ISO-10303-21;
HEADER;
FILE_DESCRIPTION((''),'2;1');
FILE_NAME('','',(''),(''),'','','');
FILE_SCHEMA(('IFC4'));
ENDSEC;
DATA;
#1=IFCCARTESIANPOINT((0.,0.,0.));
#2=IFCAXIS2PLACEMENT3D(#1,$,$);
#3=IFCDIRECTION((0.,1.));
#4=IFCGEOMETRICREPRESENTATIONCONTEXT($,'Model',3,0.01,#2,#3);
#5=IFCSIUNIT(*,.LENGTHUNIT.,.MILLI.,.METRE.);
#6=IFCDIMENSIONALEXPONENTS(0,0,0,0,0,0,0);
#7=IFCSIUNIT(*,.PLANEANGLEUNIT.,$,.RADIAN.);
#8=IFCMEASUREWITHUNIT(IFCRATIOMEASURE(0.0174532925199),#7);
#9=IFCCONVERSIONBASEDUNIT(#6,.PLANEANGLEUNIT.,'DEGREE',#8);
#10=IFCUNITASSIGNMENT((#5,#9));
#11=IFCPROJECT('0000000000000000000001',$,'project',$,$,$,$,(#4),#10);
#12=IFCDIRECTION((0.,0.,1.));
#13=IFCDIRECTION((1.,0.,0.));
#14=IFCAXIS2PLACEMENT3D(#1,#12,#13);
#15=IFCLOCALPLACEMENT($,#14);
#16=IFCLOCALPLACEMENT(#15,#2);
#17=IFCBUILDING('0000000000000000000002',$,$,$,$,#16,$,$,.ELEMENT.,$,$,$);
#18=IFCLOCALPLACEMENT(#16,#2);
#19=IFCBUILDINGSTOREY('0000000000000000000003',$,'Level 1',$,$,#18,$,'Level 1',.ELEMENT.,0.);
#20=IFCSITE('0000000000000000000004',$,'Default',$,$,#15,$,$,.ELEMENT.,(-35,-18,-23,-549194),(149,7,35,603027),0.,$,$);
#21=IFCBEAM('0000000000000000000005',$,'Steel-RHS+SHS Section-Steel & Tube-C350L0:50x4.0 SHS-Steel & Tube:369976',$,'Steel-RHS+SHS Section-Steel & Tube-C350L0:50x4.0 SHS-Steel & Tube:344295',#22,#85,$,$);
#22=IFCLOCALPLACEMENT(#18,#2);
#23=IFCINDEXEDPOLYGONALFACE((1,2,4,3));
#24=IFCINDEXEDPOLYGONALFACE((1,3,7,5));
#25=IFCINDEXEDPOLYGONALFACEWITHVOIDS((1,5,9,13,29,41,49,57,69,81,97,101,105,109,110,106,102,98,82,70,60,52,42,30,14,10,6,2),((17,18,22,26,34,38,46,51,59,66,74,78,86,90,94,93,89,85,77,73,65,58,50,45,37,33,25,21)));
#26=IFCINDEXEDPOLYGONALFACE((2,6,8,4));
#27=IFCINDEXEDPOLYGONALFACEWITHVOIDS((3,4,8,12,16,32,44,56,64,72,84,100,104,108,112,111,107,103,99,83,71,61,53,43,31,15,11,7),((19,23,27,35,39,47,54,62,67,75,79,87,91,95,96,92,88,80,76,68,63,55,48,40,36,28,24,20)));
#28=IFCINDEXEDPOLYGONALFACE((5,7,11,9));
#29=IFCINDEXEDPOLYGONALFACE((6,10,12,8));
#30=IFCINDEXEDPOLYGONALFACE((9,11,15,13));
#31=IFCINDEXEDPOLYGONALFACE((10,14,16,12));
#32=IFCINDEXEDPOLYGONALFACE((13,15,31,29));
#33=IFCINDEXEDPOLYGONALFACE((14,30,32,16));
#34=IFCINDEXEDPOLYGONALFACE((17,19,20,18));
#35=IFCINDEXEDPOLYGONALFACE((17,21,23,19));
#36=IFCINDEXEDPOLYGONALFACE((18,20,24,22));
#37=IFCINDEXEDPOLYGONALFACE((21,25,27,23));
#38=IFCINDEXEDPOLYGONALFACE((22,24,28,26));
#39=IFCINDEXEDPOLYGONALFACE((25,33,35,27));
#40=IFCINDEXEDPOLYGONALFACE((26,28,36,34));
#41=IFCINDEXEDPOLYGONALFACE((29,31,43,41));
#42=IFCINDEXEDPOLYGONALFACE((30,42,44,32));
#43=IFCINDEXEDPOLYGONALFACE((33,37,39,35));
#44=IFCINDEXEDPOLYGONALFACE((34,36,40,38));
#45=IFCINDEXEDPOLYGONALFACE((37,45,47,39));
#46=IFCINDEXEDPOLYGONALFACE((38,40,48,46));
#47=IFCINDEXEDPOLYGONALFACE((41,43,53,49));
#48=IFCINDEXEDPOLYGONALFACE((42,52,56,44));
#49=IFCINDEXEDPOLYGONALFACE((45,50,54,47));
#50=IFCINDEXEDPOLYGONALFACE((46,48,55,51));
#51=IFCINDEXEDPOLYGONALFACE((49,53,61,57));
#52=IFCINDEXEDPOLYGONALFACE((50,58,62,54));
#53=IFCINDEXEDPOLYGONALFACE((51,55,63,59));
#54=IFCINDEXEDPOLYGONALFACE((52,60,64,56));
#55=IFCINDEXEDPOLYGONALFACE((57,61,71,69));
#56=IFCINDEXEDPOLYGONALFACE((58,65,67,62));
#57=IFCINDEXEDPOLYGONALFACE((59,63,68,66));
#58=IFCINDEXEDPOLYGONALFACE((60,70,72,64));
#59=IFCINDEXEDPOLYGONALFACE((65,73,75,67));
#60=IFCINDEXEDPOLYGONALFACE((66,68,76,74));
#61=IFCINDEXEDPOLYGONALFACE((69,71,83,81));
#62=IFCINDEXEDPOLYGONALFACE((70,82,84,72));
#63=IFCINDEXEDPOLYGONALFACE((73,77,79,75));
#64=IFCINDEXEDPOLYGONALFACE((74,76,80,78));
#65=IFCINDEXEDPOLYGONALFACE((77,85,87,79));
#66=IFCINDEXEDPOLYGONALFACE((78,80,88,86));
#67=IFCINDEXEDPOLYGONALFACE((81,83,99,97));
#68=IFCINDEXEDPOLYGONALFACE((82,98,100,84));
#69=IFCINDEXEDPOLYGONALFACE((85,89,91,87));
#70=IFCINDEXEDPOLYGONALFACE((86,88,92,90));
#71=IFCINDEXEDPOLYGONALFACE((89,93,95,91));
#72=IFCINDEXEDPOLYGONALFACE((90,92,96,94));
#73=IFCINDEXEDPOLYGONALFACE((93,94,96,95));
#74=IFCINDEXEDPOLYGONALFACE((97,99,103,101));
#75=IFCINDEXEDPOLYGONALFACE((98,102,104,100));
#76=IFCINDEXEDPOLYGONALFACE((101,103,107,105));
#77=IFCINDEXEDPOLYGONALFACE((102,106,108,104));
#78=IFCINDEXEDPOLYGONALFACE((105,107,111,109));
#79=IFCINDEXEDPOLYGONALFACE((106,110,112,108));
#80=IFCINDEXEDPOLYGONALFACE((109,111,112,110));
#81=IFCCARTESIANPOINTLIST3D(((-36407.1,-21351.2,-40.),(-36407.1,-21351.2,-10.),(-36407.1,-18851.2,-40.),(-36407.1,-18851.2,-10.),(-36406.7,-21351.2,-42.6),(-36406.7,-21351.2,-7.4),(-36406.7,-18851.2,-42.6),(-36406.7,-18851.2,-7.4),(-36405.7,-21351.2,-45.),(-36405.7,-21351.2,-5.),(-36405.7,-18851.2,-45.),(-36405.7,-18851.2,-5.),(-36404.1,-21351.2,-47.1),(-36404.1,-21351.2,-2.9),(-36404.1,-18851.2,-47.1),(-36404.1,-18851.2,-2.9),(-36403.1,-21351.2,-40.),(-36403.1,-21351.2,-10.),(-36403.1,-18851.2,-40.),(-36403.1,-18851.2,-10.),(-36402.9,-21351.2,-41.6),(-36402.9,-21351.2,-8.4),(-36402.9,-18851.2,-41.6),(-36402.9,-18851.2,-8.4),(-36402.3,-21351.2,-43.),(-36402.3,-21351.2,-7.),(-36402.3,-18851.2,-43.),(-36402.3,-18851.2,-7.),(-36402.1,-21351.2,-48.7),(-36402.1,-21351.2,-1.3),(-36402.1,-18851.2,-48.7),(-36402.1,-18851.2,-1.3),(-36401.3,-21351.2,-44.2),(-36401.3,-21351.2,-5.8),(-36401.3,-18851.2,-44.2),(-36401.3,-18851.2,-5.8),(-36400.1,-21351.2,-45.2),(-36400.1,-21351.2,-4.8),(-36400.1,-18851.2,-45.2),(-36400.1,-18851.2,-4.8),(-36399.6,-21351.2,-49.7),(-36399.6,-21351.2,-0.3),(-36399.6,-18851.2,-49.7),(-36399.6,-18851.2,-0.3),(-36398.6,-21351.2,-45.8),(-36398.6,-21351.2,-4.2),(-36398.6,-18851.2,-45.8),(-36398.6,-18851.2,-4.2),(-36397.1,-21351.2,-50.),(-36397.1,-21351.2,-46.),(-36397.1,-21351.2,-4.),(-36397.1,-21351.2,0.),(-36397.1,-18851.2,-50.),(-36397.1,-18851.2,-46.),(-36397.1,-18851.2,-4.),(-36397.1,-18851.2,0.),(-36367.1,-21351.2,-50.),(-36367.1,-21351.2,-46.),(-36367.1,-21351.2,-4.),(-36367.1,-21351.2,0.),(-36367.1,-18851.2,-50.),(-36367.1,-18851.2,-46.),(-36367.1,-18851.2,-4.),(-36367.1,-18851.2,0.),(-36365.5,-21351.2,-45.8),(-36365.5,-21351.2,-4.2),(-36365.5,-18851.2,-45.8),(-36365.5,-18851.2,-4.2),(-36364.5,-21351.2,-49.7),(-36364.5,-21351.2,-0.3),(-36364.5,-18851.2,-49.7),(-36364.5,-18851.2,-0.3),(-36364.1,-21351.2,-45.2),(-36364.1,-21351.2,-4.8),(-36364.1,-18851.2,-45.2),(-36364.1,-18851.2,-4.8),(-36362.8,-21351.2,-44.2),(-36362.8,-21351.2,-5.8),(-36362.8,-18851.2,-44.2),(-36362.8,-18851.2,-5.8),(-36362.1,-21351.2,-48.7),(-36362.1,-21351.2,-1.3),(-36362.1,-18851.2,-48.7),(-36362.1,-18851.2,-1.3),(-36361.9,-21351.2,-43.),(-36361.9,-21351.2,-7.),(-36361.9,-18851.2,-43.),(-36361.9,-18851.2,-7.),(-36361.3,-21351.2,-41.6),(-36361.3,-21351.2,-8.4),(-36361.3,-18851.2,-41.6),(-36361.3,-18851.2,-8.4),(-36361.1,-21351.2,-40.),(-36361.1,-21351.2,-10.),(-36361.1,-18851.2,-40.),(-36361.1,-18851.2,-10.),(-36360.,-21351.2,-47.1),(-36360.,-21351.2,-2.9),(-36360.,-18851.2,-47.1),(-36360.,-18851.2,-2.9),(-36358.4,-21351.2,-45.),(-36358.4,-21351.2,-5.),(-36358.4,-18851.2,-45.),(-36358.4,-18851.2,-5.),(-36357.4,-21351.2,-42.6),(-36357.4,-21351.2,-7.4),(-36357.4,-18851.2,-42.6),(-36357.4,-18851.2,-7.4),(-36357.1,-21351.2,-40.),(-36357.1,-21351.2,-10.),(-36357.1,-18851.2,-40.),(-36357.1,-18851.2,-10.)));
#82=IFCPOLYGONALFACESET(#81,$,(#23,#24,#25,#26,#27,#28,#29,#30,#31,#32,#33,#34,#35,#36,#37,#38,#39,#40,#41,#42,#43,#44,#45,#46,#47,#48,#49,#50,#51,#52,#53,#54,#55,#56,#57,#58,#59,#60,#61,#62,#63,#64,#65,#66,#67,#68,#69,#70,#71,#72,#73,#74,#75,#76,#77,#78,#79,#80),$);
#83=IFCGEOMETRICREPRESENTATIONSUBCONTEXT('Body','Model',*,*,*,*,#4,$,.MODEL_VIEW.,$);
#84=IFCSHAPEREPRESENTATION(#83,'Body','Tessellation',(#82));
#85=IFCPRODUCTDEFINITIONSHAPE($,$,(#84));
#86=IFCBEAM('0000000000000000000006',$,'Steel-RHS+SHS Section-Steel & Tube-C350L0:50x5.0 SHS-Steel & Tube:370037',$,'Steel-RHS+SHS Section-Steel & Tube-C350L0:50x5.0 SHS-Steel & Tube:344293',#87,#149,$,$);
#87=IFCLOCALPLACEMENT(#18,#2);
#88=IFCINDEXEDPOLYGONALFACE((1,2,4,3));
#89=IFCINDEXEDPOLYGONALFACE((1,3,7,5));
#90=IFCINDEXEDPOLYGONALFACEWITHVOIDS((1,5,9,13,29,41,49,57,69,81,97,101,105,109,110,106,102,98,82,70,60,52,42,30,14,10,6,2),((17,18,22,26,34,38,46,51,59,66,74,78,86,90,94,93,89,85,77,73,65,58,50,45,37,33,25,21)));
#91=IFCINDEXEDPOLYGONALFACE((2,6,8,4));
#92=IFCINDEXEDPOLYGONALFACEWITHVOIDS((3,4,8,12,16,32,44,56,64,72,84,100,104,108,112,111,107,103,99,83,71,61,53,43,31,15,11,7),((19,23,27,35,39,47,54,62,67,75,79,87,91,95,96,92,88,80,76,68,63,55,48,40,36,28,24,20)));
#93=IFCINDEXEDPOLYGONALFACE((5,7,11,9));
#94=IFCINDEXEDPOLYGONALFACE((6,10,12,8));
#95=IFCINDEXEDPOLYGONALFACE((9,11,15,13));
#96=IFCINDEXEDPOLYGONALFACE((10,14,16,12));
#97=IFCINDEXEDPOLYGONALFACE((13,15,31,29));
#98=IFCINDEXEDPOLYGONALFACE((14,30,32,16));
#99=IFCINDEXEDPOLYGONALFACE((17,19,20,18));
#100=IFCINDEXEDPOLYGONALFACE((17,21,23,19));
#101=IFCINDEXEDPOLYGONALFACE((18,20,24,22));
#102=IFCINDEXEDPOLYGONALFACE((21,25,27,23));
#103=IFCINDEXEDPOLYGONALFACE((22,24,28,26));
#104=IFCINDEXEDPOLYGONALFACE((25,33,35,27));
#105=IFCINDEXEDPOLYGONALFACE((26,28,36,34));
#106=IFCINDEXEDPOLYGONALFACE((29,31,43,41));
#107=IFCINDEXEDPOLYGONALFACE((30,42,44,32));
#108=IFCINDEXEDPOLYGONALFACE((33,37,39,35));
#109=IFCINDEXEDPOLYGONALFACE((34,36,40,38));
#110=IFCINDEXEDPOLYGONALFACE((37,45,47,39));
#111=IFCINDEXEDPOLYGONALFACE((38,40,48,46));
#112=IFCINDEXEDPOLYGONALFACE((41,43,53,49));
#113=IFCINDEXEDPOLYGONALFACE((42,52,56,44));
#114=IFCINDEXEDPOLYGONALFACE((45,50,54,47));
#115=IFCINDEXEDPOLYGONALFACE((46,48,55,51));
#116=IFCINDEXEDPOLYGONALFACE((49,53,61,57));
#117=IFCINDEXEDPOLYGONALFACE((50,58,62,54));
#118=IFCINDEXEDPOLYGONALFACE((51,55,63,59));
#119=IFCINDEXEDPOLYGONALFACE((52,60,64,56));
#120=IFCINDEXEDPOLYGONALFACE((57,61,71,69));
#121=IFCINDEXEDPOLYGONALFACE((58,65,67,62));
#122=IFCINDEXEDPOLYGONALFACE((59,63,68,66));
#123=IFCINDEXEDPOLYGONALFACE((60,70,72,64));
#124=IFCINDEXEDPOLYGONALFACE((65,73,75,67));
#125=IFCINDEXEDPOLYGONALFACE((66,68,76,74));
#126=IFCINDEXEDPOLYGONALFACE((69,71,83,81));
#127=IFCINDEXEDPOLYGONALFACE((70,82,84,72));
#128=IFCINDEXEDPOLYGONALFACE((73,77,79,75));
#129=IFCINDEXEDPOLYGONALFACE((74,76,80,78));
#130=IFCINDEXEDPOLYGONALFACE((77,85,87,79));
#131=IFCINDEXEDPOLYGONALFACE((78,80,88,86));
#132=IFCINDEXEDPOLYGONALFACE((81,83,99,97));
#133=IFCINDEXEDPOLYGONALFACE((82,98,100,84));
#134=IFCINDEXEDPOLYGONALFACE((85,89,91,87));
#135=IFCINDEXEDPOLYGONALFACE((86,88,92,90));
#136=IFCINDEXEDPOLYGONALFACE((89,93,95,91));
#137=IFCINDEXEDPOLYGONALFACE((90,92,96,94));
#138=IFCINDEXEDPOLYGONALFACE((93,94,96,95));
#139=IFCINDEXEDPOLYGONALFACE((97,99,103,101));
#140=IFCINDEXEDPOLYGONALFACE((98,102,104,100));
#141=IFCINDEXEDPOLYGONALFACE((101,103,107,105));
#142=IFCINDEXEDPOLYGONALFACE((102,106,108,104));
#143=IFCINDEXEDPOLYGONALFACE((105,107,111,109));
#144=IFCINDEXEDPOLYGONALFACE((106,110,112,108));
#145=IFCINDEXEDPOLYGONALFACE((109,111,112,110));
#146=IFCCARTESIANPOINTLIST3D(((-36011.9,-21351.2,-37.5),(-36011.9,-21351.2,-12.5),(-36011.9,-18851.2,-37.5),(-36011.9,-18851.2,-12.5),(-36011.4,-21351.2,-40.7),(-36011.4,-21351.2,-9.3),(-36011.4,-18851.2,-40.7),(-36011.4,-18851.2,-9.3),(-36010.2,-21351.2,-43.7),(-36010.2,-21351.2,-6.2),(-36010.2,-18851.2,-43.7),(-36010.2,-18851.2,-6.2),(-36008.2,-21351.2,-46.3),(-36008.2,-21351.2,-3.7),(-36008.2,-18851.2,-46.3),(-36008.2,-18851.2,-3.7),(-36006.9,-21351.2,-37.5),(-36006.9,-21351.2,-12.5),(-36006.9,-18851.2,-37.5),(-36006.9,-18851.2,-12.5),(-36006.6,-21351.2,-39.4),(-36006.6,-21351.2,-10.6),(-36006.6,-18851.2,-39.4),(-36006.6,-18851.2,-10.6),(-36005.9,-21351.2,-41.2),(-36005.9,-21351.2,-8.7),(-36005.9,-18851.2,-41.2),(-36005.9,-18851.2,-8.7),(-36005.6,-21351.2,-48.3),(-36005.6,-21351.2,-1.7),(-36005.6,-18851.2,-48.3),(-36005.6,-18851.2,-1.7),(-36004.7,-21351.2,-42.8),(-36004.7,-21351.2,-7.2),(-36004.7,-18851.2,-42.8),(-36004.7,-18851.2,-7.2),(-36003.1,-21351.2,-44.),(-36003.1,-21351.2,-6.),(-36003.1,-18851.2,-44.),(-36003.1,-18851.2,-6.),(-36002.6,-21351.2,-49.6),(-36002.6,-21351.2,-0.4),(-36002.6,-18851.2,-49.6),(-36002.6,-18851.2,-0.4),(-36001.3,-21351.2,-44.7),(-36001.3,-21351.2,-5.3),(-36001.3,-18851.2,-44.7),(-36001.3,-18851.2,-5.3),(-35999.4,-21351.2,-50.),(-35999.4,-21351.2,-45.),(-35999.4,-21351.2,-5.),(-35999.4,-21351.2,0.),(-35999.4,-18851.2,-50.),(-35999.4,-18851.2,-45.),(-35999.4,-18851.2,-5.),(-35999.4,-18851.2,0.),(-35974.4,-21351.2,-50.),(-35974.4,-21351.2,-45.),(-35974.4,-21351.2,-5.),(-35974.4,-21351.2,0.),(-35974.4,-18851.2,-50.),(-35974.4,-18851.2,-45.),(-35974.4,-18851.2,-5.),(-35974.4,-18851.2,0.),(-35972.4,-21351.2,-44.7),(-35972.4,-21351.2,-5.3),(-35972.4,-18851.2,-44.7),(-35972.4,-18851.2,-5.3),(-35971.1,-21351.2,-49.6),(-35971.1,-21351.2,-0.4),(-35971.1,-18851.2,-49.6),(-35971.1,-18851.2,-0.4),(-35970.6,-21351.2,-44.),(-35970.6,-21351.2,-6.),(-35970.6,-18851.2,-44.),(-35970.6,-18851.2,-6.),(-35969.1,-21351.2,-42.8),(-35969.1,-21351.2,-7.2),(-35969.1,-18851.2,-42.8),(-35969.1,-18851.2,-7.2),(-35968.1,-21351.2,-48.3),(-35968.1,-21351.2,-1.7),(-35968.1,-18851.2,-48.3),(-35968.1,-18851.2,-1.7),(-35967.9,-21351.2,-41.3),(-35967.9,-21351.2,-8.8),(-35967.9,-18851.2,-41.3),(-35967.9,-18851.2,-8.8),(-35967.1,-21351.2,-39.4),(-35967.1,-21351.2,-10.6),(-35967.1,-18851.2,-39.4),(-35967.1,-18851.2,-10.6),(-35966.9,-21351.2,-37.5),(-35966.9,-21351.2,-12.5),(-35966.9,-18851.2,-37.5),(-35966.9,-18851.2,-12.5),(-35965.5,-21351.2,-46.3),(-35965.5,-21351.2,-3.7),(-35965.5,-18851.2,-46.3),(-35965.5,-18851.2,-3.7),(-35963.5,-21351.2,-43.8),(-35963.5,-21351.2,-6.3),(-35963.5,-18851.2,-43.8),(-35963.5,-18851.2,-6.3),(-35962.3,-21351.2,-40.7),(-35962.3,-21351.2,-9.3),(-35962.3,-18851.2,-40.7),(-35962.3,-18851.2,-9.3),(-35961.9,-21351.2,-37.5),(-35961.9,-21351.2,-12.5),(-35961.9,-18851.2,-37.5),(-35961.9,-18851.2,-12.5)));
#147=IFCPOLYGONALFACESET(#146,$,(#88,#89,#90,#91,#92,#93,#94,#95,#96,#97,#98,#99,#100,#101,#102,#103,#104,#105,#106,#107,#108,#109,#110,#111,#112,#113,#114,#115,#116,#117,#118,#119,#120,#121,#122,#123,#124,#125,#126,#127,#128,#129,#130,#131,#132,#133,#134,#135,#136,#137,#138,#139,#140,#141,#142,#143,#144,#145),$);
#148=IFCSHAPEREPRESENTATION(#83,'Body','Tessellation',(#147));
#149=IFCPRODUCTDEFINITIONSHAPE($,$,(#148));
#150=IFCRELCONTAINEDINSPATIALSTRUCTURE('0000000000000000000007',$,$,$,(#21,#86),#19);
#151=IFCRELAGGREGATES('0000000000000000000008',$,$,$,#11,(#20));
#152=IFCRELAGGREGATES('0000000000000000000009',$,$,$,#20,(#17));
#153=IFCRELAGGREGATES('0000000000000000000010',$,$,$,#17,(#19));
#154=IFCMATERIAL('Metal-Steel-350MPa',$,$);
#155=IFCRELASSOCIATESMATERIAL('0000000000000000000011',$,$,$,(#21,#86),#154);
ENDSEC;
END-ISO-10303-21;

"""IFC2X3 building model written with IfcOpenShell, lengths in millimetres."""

from ifc_helpers import new_model, entity, si_unit, converted_unit, direction, frame, frame_2d, origin, origin_with_axes, place, context, subcontext, project, spatial, polyline, circle_curve, parameter, trimmed, segment, composite_curve, outline, extrude, material, element, save


model = new_model("IFC2X3")

# Units and contexts
model_context = context("Model", 3, precision=0.01, world=origin(), true_north=direction((0.0, 1.0)))
body_context = subcontext(model_context, "Body", "Model", "MODEL_VIEW")
ifc_project = project(units=[si_unit("LENGTHUNIT", "METRE", prefix="MILLI"), converted_unit("PLANEANGLEUNIT", "DEGREE", entity("IfcRatioMeasure", 0.0174532925199), si_unit("PLANEANGLEUNIT", "RADIAN"), dimensions=[0, 0, 0, 0, 0, 0, 0])], contexts=[model_context])

# Site, building, storey
site_placement = place(None, origin_with_axes())
site = spatial("IfcSite", under=ifc_project, at=site_placement, Name="Default", CompositionType="ELEMENT", RefLatitude=(-35, -18, -23, -549194), RefLongitude=(149, 7, 35, 603027), RefElevation=0.0)
building_placement = place(site_placement, origin())
building = spatial("IfcBuilding", under=site, at=building_placement, CompositionType="ELEMENT")
storey_placement = place(building_placement, origin())
storey = spatial("IfcBuildingStorey", under=building, at=storey_placement, Name="Level 1", LongName="Level 1", CompositionType="ELEMENT", Elevation=0.0)

# Beams
ifc_material = material(Name="Metal-Steel-350MPa")
beam_1_placement = place(storey_placement, frame((-36382.1, -18851.2, 0.0), z_axis=(0.0, 0.0, 1.0), x_axis=(0.0, -1.0, 0.0)))
element("IfcBeam", 1, at=beam_1_placement, inside=storey, material=ifc_material, Name="Steel-RHS+SHS Section-Steel & Tube-C350L0:50x4.0 SHS-Steel & Tube:369976", ObjectType="Steel-RHS+SHS Section-Steel & Tube-C350L0:50x4.0 SHS-Steel & Tube:344295", context=body_context, shape_type="SweptSolid", body=[
    extrude(outline(composite_curve([segment(trimmed(circle_curve(frame_2d((-15.0, -15.0), x_axis=(1.0, 0.0)), 10.0), [parameter(180.0)], [parameter(270.0)], True, "PARAMETER"), True, "CONTINUOUS"), segment(polyline([(-15.0, -25.0), (15.0, -25.0)]), True, "CONTINUOUS"), segment(trimmed(circle_curve(frame_2d((15.0, -15.0), x_axis=(1.0, 0.0)), 10.0), [parameter(270.0)], [parameter(0.0)], True, "PARAMETER"), True, "CONTINUOUS"), segment(polyline([(25.0, -15.0), (25.0, 15.0)]), True, "CONTINUOUS"), segment(trimmed(circle_curve(frame_2d((15.0, 15.0), x_axis=(1.0, 0.0)), 10.0), [parameter(0.0)], [parameter(90.0)], True, "PARAMETER"), True, "CONTINUOUS"), segment(polyline([(15.0, 25.0), (-15.0, 25.0)]), True, "CONTINUOUS"), segment(trimmed(circle_curve(frame_2d((-15.0, 15.0), x_axis=(1.0, 0.0)), 10.0), [parameter(90.0)], [parameter(180.0)], True, "PARAMETER"), True, "CONTINUOUS"), segment(polyline([(-25.0, 15.0), (-25.0, -15.0)]), True, "CONTINUOUS")], self_intersect=False), holes=[composite_curve([segment(polyline([(15.0, -21.0), (-15.0, -21.0)]), True, "CONTINUOUS"), segment(trimmed(circle_curve(frame_2d((-15.0, -15.0), x_axis=(1.0, 0.0)), 6.0), [parameter(180.0)], [parameter(270.0)], True, "PARAMETER"), False, "CONTINUOUS"), segment(polyline([(-21.0, -15.0), (-21.0, 15.0)]), True, "CONTINUOUS"), segment(trimmed(circle_curve(frame_2d((-15.0, 15.0), x_axis=(1.0, 0.0)), 6.0), [parameter(90.0)], [parameter(180.0)], True, "PARAMETER"), False, "CONTINUOUS"), segment(polyline([(-15.0, 21.0), (15.0, 21.0)]), True, "CONTINUOUS"), segment(trimmed(circle_curve(frame_2d((15.0, 15.0), x_axis=(1.0, 0.0)), 6.0), [parameter(360.0)], [parameter(90.0)], True, "PARAMETER"), False, "CONTINUOUS"), segment(polyline([(21.0, 15.0), (21.0, -15.0)]), True, "CONTINUOUS"), segment(trimmed(circle_curve(frame_2d((15.0, -15.0), x_axis=(1.0, 0.0)), 6.0), [parameter(270.0)], [parameter(0.0)], True, "PARAMETER"), False, "CONTINUOUS")], self_intersect=False)]), frame((0.0, 0.0, -25.0), z_axis=(1.0, 0.0, 0.0), x_axis=(0.0, -1.0, 0.0)), (0.0, 0.0, 1.0), 2500.0),
])
beam_2_placement = place(storey_placement, frame((-35986.9, -18851.2, 0.0), z_axis=(0.0, 0.0, 1.0), x_axis=(0.0, -1.0, 0.0)))
element("IfcBeam", 2, at=beam_2_placement, inside=storey, material=ifc_material, Name="Steel-RHS+SHS Section-Steel & Tube-C350L0:50x5.0 SHS-Steel & Tube:370037", ObjectType="Steel-RHS+SHS Section-Steel & Tube-C350L0:50x5.0 SHS-Steel & Tube:344293", context=body_context, shape_type="SweptSolid", body=[
    extrude(outline(composite_curve([segment(trimmed(circle_curve(frame_2d((-12.5, -12.5), x_axis=(1.0, 0.0)), 12.5), [parameter(180.0)], [parameter(270.0)], True, "PARAMETER"), True, "CONTINUOUS"), segment(polyline([(-12.5, -25.0), (12.5, -25.0)]), True, "CONTINUOUS"), segment(trimmed(circle_curve(frame_2d((12.5, -12.5), x_axis=(1.0, 0.0)), 12.5), [parameter(270.0)], [parameter(0.0)], True, "PARAMETER"), True, "CONTINUOUS"), segment(polyline([(25.0, -12.5), (25.0, 12.5)]), True, "CONTINUOUS"), segment(trimmed(circle_curve(frame_2d((12.5, 12.5), x_axis=(1.0, 0.0)), 12.5), [parameter(0.0)], [parameter(90.0)], True, "PARAMETER"), True, "CONTINUOUS"), segment(polyline([(12.5, 25.0), (-12.5, 25.0)]), True, "CONTINUOUS"), segment(trimmed(circle_curve(frame_2d((-12.5, 12.5), x_axis=(1.0, 0.0)), 12.5), [parameter(90.0)], [parameter(180.0)], True, "PARAMETER"), True, "CONTINUOUS"), segment(polyline([(-25.0, 12.5), (-25.0, -12.5)]), True, "CONTINUOUS")], self_intersect=False), holes=[composite_curve([segment(polyline([(12.5, -20.0), (-12.5, -20.0)]), True, "CONTINUOUS"), segment(trimmed(circle_curve(frame_2d((-12.5, -12.5), x_axis=(1.0, 0.0)), 7.5), [parameter(180.0)], [parameter(270.0)], True, "PARAMETER"), False, "CONTINUOUS"), segment(polyline([(-20.0, -12.5), (-20.0, 12.5)]), True, "CONTINUOUS"), segment(trimmed(circle_curve(frame_2d((-12.5, 12.5), x_axis=(1.0, 0.0)), 7.5), [parameter(90.0)], [parameter(180.0)], True, "PARAMETER"), False, "CONTINUOUS"), segment(polyline([(-12.5, 20.0), (12.5, 20.0)]), True, "CONTINUOUS"), segment(trimmed(circle_curve(frame_2d((12.5, 12.5), x_axis=(1.0, 0.0)), 7.5), [parameter(360.0)], [parameter(90.0)], True, "PARAMETER"), False, "CONTINUOUS"), segment(polyline([(20.0, 12.5), (20.0, -12.5)]), True, "CONTINUOUS"), segment(trimmed(circle_curve(frame_2d((12.5, -12.5), x_axis=(1.0, 0.0)), 7.5), [parameter(270.0)], [parameter(0.0)], True, "PARAMETER"), False, "CONTINUOUS")], self_intersect=False)]), frame((0.0, 0.0, -25.0), z_axis=(1.0, 0.0, 0.0), x_axis=(0.0, -1.0, 0.0)), (0.0, 0.0, 1.0), 2500.0),
])

save(model, "model.ifc")
